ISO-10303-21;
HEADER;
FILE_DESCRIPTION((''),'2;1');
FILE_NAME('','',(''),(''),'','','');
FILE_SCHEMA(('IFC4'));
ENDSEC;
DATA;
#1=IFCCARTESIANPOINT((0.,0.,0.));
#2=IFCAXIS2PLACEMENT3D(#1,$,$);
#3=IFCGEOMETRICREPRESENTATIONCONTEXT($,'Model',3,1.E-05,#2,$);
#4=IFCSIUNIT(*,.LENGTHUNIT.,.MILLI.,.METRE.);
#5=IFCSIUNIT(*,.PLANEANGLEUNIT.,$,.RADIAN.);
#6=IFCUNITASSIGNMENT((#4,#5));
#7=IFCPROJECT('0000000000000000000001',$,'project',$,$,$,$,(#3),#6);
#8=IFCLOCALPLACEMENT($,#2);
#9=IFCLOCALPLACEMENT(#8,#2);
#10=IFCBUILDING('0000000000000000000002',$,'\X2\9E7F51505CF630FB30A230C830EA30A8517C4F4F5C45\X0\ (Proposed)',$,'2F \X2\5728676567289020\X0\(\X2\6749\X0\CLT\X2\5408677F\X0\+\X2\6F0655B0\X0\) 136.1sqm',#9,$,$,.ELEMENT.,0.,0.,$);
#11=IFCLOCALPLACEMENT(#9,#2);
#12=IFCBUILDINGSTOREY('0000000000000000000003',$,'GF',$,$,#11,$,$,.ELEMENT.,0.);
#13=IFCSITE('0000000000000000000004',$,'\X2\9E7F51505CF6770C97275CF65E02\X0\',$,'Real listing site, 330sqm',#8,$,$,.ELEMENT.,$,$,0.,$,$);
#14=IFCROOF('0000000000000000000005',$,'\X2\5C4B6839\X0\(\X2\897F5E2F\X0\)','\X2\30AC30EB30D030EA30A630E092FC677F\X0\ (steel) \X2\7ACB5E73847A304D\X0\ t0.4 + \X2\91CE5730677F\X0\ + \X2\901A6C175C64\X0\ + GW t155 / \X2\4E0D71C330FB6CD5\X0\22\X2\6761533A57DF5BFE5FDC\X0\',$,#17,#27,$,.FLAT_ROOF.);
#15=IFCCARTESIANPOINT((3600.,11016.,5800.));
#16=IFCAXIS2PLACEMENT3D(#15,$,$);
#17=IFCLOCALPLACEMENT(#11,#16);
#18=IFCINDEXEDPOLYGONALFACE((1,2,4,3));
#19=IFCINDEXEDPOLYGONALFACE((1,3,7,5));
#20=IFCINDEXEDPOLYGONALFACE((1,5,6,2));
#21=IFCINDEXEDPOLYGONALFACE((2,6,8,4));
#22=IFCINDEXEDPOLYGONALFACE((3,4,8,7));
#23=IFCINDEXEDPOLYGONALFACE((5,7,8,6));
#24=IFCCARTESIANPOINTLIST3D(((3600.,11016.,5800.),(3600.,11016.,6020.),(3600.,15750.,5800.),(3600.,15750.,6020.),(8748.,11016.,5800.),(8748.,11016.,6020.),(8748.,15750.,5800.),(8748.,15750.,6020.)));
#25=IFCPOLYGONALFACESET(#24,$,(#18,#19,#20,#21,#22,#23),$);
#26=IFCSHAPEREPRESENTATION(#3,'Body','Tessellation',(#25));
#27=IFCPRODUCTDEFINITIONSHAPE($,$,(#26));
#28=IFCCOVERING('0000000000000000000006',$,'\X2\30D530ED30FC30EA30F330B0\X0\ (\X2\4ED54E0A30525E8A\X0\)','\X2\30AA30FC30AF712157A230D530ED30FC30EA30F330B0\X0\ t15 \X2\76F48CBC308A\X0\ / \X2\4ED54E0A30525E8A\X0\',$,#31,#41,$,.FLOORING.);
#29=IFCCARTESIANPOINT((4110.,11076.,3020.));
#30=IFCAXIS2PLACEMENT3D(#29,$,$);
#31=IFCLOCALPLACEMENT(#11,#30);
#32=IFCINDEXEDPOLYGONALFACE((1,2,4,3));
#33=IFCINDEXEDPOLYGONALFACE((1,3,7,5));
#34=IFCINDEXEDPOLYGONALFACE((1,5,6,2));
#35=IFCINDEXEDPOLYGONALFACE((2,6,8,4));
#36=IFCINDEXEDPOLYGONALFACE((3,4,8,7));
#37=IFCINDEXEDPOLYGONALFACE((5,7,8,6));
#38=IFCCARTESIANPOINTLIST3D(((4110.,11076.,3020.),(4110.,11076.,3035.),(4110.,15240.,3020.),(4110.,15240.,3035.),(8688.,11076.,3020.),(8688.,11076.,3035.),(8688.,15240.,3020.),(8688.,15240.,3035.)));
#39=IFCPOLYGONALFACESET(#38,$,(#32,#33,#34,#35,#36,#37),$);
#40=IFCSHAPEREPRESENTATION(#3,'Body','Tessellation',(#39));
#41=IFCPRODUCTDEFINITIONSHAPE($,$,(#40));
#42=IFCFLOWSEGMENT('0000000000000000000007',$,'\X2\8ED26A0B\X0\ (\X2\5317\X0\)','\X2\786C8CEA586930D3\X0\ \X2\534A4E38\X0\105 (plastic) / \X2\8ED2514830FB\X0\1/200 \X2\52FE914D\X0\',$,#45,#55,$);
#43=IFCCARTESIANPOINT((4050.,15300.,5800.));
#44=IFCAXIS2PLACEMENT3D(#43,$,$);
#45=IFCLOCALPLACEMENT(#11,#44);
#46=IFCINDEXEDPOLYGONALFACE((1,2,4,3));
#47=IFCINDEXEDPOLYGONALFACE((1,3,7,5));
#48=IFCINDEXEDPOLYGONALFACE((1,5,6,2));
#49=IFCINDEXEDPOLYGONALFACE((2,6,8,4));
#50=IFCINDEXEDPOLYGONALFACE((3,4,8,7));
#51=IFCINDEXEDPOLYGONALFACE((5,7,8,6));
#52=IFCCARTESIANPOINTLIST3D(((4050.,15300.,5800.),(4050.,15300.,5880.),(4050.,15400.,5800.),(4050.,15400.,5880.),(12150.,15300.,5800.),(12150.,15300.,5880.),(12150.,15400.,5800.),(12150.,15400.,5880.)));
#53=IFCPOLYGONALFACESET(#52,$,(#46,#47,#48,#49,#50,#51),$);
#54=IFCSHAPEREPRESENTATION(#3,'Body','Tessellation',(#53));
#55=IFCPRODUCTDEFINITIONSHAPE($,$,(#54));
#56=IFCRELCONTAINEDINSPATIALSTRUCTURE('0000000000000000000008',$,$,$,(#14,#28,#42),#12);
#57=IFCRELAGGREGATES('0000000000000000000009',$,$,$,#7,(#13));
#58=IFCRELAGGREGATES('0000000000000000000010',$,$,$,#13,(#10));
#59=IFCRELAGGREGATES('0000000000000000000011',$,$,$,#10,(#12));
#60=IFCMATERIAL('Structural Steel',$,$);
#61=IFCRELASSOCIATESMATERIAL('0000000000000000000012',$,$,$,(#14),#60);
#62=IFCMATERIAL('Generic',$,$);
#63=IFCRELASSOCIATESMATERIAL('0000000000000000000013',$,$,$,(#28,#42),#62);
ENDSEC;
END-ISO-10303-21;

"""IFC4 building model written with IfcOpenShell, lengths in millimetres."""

from ifc_helpers import new_model, si_unit, frame, frame_2d, origin, place, context, project, spatial, rectangle, extrude, material, element, save


model = new_model("IFC4")

# Units and contexts
model_context = context("Model", 3, precision=1e-05, world=origin())
ifc_project = project(units=[si_unit("LENGTHUNIT", "METRE", prefix="MILLI"), si_unit("PLANEANGLEUNIT", "RADIAN")], contexts=[model_context])

# Site, building, storey
site_placement = place(None, origin())
site = spatial("IfcSite", under=ifc_project, at=site_placement, Name="鹿児島県霧島市", ObjectType="Real listing site, 330sqm", CompositionType="ELEMENT", RefElevation=0.0)
building_placement = place(site_placement, origin())
building = spatial("IfcBuilding", under=site, at=building_placement, Name="鹿児島・アトリエ兼住居 (Proposed)", ObjectType="2F 在来木造(杉CLT合板+漆喰) 136.1sqm", CompositionType="ELEMENT", ElevationOfRefHeight=0.0, ElevationOfTerrain=0.0)
storey_placement = place(building_placement, origin())
storey = spatial("IfcBuildingStorey", under=building, at=storey_placement, Name="GF", CompositionType="ELEMENT", Elevation=0.0)

# Roof
ifc_material_1 = material(Name="Structural Steel")
for number, where, name in (
    (1, (3600.0, 11016.0, 5800.0), "屋根(西帯)"),
):
    element("IfcRoof", number, at=place(storey_placement, frame(where)), inside=storey, material=ifc_material_1, Name=name, Description="ガルバリウム鋼板 (steel) 立平葺き t0.4 + 野地板 + 通気層 + GW t155 / 不燃・法22条区域対応", PredefinedType="FLAT_ROOF", context=model_context, shape_type="SweptSolid", body=[
        extrude(rectangle(XDim=5148.0, YDim=4734.0, at=frame_2d((2574.0, 2367.0))), frame((3600.0, 11016.0, 5800.0)), (0.0, 0.0, 1.0), 220.0),
    ])

# Covering
ifc_material_2 = material(Name="Generic")
covering_placement = place(storey_placement, frame((4110.0, 11076.0, 3020.0)))
element("IfcCovering", 2, at=covering_placement, inside=storey, material=ifc_material_2, Name="フローリング (仕上げ床)", Description="オーク無垢フローリング t15 直貼り / 仕上げ床", PredefinedType="FLOORING", context=model_context, shape_type="SweptSolid", body=[
    extrude(rectangle(XDim=4578.0, YDim=4164.0, at=frame_2d((2289.0, 2082.0))), frame((4110.0, 11076.0, 3020.0)), (0.0, 0.0, 1.0), 15.0),
])

# Flow segment
flow_segment_placement = place(storey_placement, frame((4050.0, 15300.0, 5800.0)))
element("IfcFlowSegment", 3, at=flow_segment_placement, inside=storey, material=ifc_material_2, Name="軒樋 (北)", Description="硬質塩ビ 半丸105 (plastic) / 軒先・1/200 勾配", context=model_context, shape_type="SweptSolid", body=[
    extrude(rectangle(XDim=8100.0, YDim=100.0, at=frame_2d((4050.0, 50.0))), frame((4050.0, 15300.0, 5800.0)), (0.0, 0.0, 1.0), 80.0),
])

save(model, "model.ifc")
